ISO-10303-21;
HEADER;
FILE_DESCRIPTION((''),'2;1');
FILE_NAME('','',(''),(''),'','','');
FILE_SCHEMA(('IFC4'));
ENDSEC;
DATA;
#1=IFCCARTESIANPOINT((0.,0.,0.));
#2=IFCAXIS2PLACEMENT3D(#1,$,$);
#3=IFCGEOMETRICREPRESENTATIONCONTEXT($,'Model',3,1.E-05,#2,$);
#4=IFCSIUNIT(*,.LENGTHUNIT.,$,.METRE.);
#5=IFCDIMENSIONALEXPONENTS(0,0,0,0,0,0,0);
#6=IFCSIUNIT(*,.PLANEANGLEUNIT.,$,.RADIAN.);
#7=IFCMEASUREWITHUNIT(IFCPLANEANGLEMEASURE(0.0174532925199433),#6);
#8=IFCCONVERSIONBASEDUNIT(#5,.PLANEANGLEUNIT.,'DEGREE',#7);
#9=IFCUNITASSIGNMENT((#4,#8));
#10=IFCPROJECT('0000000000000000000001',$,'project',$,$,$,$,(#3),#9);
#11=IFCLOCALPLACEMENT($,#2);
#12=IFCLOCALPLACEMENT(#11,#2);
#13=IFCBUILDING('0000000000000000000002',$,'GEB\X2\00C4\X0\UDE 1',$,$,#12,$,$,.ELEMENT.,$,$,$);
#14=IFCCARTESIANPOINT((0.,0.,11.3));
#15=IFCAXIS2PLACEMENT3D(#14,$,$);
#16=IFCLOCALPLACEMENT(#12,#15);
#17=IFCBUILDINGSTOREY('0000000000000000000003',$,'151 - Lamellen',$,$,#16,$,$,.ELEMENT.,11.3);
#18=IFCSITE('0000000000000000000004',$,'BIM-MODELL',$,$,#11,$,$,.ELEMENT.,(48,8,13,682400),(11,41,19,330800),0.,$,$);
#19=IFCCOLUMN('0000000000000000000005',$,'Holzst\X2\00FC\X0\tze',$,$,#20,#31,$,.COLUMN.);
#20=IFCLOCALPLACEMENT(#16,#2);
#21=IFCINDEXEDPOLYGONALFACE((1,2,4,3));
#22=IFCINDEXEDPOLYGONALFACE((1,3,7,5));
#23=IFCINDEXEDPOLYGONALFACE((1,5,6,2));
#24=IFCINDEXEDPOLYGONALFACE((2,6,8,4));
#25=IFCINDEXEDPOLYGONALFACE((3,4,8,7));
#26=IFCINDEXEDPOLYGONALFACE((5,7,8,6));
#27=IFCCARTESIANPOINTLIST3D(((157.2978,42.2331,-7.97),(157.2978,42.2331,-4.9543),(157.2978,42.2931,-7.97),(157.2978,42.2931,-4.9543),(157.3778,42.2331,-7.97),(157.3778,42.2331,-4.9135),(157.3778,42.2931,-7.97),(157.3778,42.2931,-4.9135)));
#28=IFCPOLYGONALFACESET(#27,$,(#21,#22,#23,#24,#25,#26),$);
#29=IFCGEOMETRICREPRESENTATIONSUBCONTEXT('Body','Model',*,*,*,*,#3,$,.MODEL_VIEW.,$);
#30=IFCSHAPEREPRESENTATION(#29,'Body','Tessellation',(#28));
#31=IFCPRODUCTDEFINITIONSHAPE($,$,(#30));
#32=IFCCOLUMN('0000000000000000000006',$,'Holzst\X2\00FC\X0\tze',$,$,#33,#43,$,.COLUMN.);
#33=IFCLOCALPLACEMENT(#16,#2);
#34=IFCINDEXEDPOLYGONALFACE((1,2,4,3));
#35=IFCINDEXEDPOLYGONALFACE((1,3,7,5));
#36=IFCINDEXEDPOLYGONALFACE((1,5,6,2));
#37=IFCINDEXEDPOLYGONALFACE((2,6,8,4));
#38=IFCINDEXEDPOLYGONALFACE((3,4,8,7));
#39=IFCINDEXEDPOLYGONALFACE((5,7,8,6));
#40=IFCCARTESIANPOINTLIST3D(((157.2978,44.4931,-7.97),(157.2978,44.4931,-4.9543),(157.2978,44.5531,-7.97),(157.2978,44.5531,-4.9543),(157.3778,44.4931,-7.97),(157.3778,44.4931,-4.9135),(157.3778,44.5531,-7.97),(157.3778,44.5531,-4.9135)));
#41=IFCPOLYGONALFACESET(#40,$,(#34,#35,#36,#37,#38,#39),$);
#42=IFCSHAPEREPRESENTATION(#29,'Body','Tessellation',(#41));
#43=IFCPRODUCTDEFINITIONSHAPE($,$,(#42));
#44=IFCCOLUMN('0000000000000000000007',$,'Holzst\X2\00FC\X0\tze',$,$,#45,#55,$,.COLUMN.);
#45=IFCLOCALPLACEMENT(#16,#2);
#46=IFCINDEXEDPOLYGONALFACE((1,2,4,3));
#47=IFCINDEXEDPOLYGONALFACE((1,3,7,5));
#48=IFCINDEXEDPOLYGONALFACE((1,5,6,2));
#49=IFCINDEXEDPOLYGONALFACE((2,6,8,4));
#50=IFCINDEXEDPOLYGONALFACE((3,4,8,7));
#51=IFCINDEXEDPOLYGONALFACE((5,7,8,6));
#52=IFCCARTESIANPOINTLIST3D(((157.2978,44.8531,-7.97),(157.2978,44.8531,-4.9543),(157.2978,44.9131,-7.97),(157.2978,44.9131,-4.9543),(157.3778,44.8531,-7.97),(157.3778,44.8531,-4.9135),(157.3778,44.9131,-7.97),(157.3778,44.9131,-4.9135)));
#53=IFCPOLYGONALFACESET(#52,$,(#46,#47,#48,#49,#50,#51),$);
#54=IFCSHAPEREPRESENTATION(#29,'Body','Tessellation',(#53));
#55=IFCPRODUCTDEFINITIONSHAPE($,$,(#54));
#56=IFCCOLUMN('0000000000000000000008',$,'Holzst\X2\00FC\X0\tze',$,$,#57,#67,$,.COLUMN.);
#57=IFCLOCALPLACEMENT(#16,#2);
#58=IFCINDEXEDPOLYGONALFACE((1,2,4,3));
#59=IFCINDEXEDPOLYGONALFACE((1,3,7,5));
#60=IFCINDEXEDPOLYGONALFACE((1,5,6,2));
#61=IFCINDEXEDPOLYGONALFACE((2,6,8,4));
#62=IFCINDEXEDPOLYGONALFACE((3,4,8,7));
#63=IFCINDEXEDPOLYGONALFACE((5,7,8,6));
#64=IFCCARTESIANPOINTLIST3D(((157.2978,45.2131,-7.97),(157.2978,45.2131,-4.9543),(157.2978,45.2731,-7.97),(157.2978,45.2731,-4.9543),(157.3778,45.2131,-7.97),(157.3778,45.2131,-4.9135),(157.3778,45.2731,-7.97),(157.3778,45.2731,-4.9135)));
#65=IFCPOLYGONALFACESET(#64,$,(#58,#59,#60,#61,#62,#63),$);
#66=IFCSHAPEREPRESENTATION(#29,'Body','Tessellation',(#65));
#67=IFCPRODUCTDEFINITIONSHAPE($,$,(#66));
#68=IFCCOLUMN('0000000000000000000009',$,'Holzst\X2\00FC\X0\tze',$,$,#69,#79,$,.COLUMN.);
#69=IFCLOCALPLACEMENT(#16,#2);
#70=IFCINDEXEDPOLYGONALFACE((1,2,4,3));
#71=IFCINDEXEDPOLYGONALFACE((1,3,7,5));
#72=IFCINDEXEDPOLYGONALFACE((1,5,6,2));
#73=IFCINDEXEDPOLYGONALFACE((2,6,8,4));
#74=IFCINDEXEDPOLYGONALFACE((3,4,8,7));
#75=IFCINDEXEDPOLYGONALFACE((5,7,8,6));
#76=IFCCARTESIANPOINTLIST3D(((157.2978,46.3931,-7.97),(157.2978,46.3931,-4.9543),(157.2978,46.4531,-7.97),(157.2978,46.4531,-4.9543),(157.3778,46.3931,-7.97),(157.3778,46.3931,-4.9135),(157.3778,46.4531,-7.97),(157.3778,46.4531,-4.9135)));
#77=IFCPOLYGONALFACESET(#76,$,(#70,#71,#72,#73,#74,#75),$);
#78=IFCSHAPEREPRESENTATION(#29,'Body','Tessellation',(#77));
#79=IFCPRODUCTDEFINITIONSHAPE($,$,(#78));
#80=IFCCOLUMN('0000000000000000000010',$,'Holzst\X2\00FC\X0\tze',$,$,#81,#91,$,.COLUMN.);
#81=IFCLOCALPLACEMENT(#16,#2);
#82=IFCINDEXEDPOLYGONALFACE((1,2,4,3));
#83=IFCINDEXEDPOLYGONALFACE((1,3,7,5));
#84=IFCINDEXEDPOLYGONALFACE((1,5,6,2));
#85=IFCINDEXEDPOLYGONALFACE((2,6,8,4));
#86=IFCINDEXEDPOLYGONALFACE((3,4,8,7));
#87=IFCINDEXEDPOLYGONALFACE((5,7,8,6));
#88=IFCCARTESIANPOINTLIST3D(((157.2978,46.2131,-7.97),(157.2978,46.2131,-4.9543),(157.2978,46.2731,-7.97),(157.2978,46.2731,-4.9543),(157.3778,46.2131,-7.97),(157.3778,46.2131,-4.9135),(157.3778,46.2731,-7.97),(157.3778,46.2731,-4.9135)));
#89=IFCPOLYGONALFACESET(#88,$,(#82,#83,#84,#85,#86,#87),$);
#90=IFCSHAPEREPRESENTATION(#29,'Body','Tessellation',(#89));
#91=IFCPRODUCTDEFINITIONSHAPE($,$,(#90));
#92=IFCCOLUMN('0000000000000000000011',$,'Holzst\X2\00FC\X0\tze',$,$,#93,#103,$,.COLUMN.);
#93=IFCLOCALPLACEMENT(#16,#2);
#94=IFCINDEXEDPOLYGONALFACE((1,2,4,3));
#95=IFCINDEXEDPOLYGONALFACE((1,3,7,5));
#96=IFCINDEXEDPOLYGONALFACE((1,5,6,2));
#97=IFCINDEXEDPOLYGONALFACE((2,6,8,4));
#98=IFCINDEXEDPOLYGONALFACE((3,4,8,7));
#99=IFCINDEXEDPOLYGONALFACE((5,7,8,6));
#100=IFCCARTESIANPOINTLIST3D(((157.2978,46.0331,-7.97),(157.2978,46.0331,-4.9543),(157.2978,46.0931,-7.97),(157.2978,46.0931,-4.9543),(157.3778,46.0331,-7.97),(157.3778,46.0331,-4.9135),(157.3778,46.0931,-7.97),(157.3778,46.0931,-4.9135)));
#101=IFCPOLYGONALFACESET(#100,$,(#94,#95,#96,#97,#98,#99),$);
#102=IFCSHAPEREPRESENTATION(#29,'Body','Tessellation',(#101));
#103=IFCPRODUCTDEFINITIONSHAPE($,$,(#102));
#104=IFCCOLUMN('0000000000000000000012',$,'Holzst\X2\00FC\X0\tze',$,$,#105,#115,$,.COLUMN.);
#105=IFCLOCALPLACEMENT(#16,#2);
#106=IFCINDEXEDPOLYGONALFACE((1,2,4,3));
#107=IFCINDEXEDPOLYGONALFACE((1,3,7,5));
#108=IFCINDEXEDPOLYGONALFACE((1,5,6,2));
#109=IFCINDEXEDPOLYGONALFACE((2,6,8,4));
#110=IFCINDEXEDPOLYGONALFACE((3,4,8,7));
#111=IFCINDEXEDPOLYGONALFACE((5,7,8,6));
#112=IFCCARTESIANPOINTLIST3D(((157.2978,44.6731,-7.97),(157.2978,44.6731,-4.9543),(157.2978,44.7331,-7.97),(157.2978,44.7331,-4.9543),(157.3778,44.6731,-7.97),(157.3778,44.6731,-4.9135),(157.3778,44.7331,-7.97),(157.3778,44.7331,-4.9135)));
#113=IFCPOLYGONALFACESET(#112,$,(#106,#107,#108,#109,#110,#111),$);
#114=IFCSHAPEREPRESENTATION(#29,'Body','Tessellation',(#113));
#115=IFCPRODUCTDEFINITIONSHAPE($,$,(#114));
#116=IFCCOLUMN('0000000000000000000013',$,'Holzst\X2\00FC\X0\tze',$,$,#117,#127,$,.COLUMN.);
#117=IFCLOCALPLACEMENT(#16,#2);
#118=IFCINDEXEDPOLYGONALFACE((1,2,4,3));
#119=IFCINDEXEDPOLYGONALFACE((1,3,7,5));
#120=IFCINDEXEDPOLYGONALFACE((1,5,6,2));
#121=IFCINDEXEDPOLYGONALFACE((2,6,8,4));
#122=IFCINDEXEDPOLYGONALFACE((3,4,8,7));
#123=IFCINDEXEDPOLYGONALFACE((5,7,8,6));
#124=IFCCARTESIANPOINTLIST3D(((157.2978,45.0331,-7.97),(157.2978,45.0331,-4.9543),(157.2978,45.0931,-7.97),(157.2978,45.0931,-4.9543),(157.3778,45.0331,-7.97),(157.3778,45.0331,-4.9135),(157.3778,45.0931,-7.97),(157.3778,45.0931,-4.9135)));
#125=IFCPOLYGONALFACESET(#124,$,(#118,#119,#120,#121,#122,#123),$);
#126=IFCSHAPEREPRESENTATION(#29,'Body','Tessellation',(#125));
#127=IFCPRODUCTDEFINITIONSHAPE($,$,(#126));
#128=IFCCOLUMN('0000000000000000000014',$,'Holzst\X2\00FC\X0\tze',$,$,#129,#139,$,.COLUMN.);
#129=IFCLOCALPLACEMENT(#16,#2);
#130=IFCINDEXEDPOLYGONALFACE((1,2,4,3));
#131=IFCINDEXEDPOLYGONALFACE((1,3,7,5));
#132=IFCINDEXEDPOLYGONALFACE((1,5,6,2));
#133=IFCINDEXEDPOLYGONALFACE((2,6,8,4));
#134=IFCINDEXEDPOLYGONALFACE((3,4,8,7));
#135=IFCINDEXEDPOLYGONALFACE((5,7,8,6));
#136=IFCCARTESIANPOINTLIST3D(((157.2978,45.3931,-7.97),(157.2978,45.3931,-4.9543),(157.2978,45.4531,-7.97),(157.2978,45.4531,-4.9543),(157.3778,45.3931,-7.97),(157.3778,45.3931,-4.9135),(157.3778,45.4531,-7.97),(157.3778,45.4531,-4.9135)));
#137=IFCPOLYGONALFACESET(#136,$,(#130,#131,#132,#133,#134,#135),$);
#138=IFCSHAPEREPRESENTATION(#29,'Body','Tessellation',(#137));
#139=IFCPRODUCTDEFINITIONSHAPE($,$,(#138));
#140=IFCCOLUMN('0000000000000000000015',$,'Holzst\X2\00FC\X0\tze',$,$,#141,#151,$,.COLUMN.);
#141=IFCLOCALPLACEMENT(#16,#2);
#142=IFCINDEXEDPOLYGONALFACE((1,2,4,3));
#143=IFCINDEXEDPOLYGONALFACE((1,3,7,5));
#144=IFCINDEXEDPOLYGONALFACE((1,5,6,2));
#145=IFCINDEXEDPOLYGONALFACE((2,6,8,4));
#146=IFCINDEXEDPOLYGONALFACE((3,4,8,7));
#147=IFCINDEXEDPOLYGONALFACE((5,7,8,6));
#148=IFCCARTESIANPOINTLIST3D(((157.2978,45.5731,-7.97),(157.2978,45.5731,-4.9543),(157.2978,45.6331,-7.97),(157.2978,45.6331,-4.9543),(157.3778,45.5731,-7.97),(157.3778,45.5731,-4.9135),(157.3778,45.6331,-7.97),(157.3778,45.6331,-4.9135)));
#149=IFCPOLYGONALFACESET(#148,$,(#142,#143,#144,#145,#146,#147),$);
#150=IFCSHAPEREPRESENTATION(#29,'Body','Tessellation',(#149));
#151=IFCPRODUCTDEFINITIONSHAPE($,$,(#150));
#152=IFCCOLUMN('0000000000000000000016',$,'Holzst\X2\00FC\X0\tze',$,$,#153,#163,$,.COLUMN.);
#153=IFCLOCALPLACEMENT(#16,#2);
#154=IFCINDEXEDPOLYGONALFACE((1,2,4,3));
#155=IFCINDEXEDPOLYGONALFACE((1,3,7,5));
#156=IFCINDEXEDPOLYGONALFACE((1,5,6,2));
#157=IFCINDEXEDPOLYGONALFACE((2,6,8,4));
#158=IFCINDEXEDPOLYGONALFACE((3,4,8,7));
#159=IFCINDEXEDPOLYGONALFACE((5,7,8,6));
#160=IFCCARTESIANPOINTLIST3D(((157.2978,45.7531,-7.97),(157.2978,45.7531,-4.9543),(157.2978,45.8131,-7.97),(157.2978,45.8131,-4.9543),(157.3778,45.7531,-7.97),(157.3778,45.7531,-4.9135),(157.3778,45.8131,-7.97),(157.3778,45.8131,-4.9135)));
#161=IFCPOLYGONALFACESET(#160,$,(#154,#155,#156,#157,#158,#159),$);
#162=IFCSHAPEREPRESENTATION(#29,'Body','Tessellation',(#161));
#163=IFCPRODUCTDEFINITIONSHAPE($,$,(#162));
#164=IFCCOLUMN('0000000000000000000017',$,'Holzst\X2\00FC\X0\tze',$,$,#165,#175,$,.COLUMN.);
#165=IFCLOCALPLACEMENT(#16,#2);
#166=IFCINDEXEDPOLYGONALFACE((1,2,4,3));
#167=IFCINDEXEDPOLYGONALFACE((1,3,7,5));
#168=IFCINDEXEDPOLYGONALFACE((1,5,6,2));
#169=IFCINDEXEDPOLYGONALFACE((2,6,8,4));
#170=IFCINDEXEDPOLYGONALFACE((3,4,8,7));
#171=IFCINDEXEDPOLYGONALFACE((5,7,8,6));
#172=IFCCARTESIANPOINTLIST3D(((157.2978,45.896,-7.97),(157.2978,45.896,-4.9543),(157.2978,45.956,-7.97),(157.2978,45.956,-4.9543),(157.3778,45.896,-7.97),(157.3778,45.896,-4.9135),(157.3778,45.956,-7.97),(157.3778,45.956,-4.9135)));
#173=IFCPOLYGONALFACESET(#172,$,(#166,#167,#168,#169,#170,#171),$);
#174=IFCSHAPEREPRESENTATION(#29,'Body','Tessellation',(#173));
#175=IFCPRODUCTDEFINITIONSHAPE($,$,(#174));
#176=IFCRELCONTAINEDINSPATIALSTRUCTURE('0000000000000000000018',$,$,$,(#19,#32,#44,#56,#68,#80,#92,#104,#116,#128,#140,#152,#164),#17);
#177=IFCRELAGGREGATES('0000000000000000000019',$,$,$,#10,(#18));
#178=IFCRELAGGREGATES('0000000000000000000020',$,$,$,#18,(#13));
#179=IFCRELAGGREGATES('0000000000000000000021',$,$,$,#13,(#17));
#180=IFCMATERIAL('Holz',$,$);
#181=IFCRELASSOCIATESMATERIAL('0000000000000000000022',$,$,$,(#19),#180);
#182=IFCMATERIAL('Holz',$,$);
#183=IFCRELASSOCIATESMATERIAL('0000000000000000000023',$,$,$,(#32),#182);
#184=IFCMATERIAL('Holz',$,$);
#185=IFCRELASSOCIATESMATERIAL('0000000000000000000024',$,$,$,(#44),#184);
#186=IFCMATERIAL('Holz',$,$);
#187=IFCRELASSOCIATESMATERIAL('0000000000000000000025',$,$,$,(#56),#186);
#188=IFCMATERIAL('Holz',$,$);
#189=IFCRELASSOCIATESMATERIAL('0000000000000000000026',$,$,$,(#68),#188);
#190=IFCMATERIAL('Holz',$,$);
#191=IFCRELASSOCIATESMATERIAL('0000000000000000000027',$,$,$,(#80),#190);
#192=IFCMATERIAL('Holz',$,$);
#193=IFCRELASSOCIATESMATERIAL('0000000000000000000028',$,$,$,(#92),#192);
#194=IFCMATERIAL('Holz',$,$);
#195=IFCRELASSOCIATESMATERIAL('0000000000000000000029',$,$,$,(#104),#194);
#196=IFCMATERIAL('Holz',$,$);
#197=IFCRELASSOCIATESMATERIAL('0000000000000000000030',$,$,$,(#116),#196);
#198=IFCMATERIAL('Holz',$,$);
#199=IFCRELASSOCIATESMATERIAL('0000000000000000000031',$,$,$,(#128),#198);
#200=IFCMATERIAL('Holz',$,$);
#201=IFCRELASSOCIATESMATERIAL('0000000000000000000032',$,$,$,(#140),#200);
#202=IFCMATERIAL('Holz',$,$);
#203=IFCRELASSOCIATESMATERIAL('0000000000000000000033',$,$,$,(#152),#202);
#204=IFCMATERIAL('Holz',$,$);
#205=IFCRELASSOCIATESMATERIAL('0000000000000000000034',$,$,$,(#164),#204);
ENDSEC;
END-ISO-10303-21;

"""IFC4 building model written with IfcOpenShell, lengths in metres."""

from ifc_helpers import new_model, entity, si_unit, converted_unit, frame, frame_2d, origin, origin_with_axes, place, context, subcontext, project, spatial, rectangle, extrude, clip, halfspace, material, element, save


model = new_model("IFC4")

# Units and contexts
model_context = context("Model", 3, precision=1e-05, world=origin())
body_context = subcontext(model_context, "Body", "Model", "MODEL_VIEW")
ifc_project = project(units=[si_unit("LENGTHUNIT", "METRE"), converted_unit("PLANEANGLEUNIT", "DEGREE", entity("IfcPlaneAngleMeasure", 0.0174532925199433), si_unit("PLANEANGLEUNIT", "RADIAN"), dimensions=[0, 0, 0, 0, 0, 0, 0])], contexts=[model_context])

# Site, building, storey
site_placement = place(None, origin())
site = spatial("IfcSite", under=ifc_project, at=site_placement, Name="BIM-MODELL", CompositionType="ELEMENT", RefLatitude=(48, 8, 13, 682400), RefLongitude=(11, 41, 19, 330800), RefElevation=0.0)
building_placement = place(site_placement, origin())
building = spatial("IfcBuilding", under=site, at=building_placement, Name="GEBÄUDE 1", CompositionType="ELEMENT")
storey_placement = place(building_placement, frame((0.0, 0.0, 11.3)))
storey = spatial("IfcBuildingStorey", under=building, at=storey_placement, Name="151 - Lamellen", CompositionType="ELEMENT", Elevation=11.3)

# Columns
ifc_material_1 = material(Name="Holz")
column_1_placement = place(storey_placement, frame((157.3778, 42.2331, -7.97)))
element("IfcColumn", 1, at=column_1_placement, inside=storey, material=ifc_material_1, Name="Holzstütze", PredefinedType="COLUMN", context=body_context, shape_type="Clipping", body=[
    clip(extrude(rectangle(XDim=0.06, YDim=0.08, at=frame_2d((-0.04, 0.03), x_axis=(0.0, 1.0))), origin_with_axes(), (0.0, 0.0, 1.0), 3.0565), halfspace(frame((-0.04, 0.03, 3.0361), z_axis=(0.45399, 0.0, -0.891007), x_axis=(-0.891007, 0.0, -0.45399)), True)),
])
ifc_material_2 = material(Name="Holz")
column_2_placement = place(storey_placement, frame((157.3778, 44.4931, -7.97)))
element("IfcColumn", 2, at=column_2_placement, inside=storey, material=ifc_material_2, Name="Holzstütze", PredefinedType="COLUMN", context=body_context, shape_type="Clipping", body=[
    clip(extrude(rectangle(XDim=0.06, YDim=0.08, at=frame_2d((-0.04, 0.03), x_axis=(0.0, 1.0))), origin_with_axes(), (0.0, 0.0, 1.0), 3.0565), halfspace(frame((-0.04, 0.03, 3.0361), z_axis=(0.45399, 0.0, -0.891007), x_axis=(-0.891007, 0.0, -0.45399)), True)),
])
ifc_material_3 = material(Name="Holz")
column_3_placement = place(storey_placement, frame((157.3778, 44.8531, -7.97)))
element("IfcColumn", 3, at=column_3_placement, inside=storey, material=ifc_material_3, Name="Holzstütze", PredefinedType="COLUMN", context=body_context, shape_type="Clipping", body=[
    clip(extrude(rectangle(XDim=0.06, YDim=0.08, at=frame_2d((-0.04, 0.03), x_axis=(0.0, 1.0))), origin_with_axes(), (0.0, 0.0, 1.0), 3.0565), halfspace(frame((-0.04, 0.03, 3.0361), z_axis=(0.45399, 0.0, -0.891007), x_axis=(-0.891007, 0.0, -0.45399)), True)),
])
ifc_material_4 = material(Name="Holz")
column_4_placement = place(storey_placement, frame((157.3778, 45.2131, -7.97)))
element("IfcColumn", 4, at=column_4_placement, inside=storey, material=ifc_material_4, Name="Holzstütze", PredefinedType="COLUMN", context=body_context, shape_type="Clipping", body=[
    clip(extrude(rectangle(XDim=0.06, YDim=0.08, at=frame_2d((-0.04, 0.03), x_axis=(0.0, 1.0))), origin_with_axes(), (0.0, 0.0, 1.0), 3.0565), halfspace(frame((-0.04, 0.03, 3.0361), z_axis=(0.45399, 0.0, -0.891007), x_axis=(-0.891007, 0.0, -0.45399)), True)),
])
ifc_material_5 = material(Name="Holz")
column_5_placement = place(storey_placement, frame((157.3778, 46.3931, -7.97)))
element("IfcColumn", 5, at=column_5_placement, inside=storey, material=ifc_material_5, Name="Holzstütze", PredefinedType="COLUMN", context=body_context, shape_type="Clipping", body=[
    clip(extrude(rectangle(XDim=0.06, YDim=0.08, at=frame_2d((-0.04, 0.03), x_axis=(0.0, 1.0))), origin_with_axes(), (0.0, 0.0, 1.0), 3.0565), halfspace(frame((-0.04, 0.03, 3.0361), z_axis=(0.45399, 0.0, -0.891007), x_axis=(-0.891007, 0.0, -0.45399)), True)),
])
ifc_material_6 = material(Name="Holz")
column_6_placement = place(storey_placement, frame((157.3778, 46.2131, -7.97)))
element("IfcColumn", 6, at=column_6_placement, inside=storey, material=ifc_material_6, Name="Holzstütze", PredefinedType="COLUMN", context=body_context, shape_type="Clipping", body=[
    clip(extrude(rectangle(XDim=0.06, YDim=0.08, at=frame_2d((-0.04, 0.03), x_axis=(0.0, 1.0))), origin_with_axes(), (0.0, 0.0, 1.0), 3.0565), halfspace(frame((-0.04, 0.03, 3.0361), z_axis=(0.45399, 0.0, -0.891007), x_axis=(-0.891007, 0.0, -0.45399)), True)),
])
ifc_material_7 = material(Name="Holz")
column_7_placement = place(storey_placement, frame((157.3778, 46.0331, -7.97)))
element("IfcColumn", 7, at=column_7_placement, inside=storey, material=ifc_material_7, Name="Holzstütze", PredefinedType="COLUMN", context=body_context, shape_type="Clipping", body=[
    clip(extrude(rectangle(XDim=0.06, YDim=0.08, at=frame_2d((-0.04, 0.03), x_axis=(0.0, 1.0))), origin_with_axes(), (0.0, 0.0, 1.0), 3.0565), halfspace(frame((-0.04, 0.03, 3.0361), z_axis=(0.45399, 0.0, -0.891007), x_axis=(-0.891007, 0.0, -0.45399)), True)),
])
ifc_material_8 = material(Name="Holz")
column_8_placement = place(storey_placement, frame((157.3778, 44.6731, -7.97)))
element("IfcColumn", 8, at=column_8_placement, inside=storey, material=ifc_material_8, Name="Holzstütze", PredefinedType="COLUMN", context=body_context, shape_type="Clipping", body=[
    clip(extrude(rectangle(XDim=0.06, YDim=0.08, at=frame_2d((-0.04, 0.03), x_axis=(0.0, 1.0))), origin_with_axes(), (0.0, 0.0, 1.0), 3.0565), halfspace(frame((-0.04, 0.03, 3.0361), z_axis=(0.45399, 0.0, -0.891007), x_axis=(-0.891007, 0.0, -0.45399)), True)),
])
ifc_material_9 = material(Name="Holz")
column_9_placement = place(storey_placement, frame((157.3778, 45.0331, -7.97)))
element("IfcColumn", 9, at=column_9_placement, inside=storey, material=ifc_material_9, Name="Holzstütze", PredefinedType="COLUMN", context=body_context, shape_type="Clipping", body=[
    clip(extrude(rectangle(XDim=0.06, YDim=0.08, at=frame_2d((-0.04, 0.03), x_axis=(0.0, 1.0))), origin_with_axes(), (0.0, 0.0, 1.0), 3.0565), halfspace(frame((-0.04, 0.03, 3.0361), z_axis=(0.45399, 0.0, -0.891007), x_axis=(-0.891007, 0.0, -0.45399)), True)),
])
ifc_material_10 = material(Name="Holz")
column_10_placement = place(storey_placement, frame((157.3778, 45.3931, -7.97)))
element("IfcColumn", 10, at=column_10_placement, inside=storey, material=ifc_material_10, Name="Holzstütze", PredefinedType="COLUMN", context=body_context, shape_type="Clipping", body=[
    clip(extrude(rectangle(XDim=0.06, YDim=0.08, at=frame_2d((-0.04, 0.03), x_axis=(0.0, 1.0))), origin_with_axes(), (0.0, 0.0, 1.0), 3.0565), halfspace(frame((-0.04, 0.03, 3.0361), z_axis=(0.45399, 0.0, -0.891007), x_axis=(-0.891007, 0.0, -0.45399)), True)),
])
ifc_material_11 = material(Name="Holz")
column_11_placement = place(storey_placement, frame((157.3778, 45.5731, -7.97)))
element("IfcColumn", 11, at=column_11_placement, inside=storey, material=ifc_material_11, Name="Holzstütze", PredefinedType="COLUMN", context=body_context, shape_type="Clipping", body=[
    clip(extrude(rectangle(XDim=0.06, YDim=0.08, at=frame_2d((-0.04, 0.03), x_axis=(0.0, 1.0))), origin_with_axes(), (0.0, 0.0, 1.0), 3.0565), halfspace(frame((-0.04, 0.03, 3.0361), z_axis=(0.45399, 0.0, -0.891007), x_axis=(-0.891007, 0.0, -0.45399)), True)),
])
ifc_material_12 = material(Name="Holz")
column_12_placement = place(storey_placement, frame((157.3778, 45.7531, -7.97)))
element("IfcColumn", 12, at=column_12_placement, inside=storey, material=ifc_material_12, Name="Holzstütze", PredefinedType="COLUMN", context=body_context, shape_type="Clipping", body=[
    clip(extrude(rectangle(XDim=0.06, YDim=0.08, at=frame_2d((-0.04, 0.03), x_axis=(0.0, 1.0))), origin_with_axes(), (0.0, 0.0, 1.0), 3.0565), halfspace(frame((-0.04, 0.03, 3.0361), z_axis=(0.45399, 0.0, -0.891007), x_axis=(-0.891007, 0.0, -0.45399)), True)),
])
ifc_material_13 = material(Name="Holz")
column_13_placement = place(storey_placement, frame((157.3778, 45.896, -7.97)))
element("IfcColumn", 13, at=column_13_placement, inside=storey, material=ifc_material_13, Name="Holzstütze", PredefinedType="COLUMN", context=body_context, shape_type="Clipping", body=[
    clip(extrude(rectangle(XDim=0.06, YDim=0.08, at=frame_2d((-0.04, 0.03), x_axis=(0.0, 1.0))), origin_with_axes(), (0.0, 0.0, 1.0), 3.0565), halfspace(frame((-0.04, 0.03, 3.0361), z_axis=(0.45399, 0.0, -0.891007), x_axis=(-0.891007, 0.0, -0.45399)), True)),
])

save(model, "model.ifc")
